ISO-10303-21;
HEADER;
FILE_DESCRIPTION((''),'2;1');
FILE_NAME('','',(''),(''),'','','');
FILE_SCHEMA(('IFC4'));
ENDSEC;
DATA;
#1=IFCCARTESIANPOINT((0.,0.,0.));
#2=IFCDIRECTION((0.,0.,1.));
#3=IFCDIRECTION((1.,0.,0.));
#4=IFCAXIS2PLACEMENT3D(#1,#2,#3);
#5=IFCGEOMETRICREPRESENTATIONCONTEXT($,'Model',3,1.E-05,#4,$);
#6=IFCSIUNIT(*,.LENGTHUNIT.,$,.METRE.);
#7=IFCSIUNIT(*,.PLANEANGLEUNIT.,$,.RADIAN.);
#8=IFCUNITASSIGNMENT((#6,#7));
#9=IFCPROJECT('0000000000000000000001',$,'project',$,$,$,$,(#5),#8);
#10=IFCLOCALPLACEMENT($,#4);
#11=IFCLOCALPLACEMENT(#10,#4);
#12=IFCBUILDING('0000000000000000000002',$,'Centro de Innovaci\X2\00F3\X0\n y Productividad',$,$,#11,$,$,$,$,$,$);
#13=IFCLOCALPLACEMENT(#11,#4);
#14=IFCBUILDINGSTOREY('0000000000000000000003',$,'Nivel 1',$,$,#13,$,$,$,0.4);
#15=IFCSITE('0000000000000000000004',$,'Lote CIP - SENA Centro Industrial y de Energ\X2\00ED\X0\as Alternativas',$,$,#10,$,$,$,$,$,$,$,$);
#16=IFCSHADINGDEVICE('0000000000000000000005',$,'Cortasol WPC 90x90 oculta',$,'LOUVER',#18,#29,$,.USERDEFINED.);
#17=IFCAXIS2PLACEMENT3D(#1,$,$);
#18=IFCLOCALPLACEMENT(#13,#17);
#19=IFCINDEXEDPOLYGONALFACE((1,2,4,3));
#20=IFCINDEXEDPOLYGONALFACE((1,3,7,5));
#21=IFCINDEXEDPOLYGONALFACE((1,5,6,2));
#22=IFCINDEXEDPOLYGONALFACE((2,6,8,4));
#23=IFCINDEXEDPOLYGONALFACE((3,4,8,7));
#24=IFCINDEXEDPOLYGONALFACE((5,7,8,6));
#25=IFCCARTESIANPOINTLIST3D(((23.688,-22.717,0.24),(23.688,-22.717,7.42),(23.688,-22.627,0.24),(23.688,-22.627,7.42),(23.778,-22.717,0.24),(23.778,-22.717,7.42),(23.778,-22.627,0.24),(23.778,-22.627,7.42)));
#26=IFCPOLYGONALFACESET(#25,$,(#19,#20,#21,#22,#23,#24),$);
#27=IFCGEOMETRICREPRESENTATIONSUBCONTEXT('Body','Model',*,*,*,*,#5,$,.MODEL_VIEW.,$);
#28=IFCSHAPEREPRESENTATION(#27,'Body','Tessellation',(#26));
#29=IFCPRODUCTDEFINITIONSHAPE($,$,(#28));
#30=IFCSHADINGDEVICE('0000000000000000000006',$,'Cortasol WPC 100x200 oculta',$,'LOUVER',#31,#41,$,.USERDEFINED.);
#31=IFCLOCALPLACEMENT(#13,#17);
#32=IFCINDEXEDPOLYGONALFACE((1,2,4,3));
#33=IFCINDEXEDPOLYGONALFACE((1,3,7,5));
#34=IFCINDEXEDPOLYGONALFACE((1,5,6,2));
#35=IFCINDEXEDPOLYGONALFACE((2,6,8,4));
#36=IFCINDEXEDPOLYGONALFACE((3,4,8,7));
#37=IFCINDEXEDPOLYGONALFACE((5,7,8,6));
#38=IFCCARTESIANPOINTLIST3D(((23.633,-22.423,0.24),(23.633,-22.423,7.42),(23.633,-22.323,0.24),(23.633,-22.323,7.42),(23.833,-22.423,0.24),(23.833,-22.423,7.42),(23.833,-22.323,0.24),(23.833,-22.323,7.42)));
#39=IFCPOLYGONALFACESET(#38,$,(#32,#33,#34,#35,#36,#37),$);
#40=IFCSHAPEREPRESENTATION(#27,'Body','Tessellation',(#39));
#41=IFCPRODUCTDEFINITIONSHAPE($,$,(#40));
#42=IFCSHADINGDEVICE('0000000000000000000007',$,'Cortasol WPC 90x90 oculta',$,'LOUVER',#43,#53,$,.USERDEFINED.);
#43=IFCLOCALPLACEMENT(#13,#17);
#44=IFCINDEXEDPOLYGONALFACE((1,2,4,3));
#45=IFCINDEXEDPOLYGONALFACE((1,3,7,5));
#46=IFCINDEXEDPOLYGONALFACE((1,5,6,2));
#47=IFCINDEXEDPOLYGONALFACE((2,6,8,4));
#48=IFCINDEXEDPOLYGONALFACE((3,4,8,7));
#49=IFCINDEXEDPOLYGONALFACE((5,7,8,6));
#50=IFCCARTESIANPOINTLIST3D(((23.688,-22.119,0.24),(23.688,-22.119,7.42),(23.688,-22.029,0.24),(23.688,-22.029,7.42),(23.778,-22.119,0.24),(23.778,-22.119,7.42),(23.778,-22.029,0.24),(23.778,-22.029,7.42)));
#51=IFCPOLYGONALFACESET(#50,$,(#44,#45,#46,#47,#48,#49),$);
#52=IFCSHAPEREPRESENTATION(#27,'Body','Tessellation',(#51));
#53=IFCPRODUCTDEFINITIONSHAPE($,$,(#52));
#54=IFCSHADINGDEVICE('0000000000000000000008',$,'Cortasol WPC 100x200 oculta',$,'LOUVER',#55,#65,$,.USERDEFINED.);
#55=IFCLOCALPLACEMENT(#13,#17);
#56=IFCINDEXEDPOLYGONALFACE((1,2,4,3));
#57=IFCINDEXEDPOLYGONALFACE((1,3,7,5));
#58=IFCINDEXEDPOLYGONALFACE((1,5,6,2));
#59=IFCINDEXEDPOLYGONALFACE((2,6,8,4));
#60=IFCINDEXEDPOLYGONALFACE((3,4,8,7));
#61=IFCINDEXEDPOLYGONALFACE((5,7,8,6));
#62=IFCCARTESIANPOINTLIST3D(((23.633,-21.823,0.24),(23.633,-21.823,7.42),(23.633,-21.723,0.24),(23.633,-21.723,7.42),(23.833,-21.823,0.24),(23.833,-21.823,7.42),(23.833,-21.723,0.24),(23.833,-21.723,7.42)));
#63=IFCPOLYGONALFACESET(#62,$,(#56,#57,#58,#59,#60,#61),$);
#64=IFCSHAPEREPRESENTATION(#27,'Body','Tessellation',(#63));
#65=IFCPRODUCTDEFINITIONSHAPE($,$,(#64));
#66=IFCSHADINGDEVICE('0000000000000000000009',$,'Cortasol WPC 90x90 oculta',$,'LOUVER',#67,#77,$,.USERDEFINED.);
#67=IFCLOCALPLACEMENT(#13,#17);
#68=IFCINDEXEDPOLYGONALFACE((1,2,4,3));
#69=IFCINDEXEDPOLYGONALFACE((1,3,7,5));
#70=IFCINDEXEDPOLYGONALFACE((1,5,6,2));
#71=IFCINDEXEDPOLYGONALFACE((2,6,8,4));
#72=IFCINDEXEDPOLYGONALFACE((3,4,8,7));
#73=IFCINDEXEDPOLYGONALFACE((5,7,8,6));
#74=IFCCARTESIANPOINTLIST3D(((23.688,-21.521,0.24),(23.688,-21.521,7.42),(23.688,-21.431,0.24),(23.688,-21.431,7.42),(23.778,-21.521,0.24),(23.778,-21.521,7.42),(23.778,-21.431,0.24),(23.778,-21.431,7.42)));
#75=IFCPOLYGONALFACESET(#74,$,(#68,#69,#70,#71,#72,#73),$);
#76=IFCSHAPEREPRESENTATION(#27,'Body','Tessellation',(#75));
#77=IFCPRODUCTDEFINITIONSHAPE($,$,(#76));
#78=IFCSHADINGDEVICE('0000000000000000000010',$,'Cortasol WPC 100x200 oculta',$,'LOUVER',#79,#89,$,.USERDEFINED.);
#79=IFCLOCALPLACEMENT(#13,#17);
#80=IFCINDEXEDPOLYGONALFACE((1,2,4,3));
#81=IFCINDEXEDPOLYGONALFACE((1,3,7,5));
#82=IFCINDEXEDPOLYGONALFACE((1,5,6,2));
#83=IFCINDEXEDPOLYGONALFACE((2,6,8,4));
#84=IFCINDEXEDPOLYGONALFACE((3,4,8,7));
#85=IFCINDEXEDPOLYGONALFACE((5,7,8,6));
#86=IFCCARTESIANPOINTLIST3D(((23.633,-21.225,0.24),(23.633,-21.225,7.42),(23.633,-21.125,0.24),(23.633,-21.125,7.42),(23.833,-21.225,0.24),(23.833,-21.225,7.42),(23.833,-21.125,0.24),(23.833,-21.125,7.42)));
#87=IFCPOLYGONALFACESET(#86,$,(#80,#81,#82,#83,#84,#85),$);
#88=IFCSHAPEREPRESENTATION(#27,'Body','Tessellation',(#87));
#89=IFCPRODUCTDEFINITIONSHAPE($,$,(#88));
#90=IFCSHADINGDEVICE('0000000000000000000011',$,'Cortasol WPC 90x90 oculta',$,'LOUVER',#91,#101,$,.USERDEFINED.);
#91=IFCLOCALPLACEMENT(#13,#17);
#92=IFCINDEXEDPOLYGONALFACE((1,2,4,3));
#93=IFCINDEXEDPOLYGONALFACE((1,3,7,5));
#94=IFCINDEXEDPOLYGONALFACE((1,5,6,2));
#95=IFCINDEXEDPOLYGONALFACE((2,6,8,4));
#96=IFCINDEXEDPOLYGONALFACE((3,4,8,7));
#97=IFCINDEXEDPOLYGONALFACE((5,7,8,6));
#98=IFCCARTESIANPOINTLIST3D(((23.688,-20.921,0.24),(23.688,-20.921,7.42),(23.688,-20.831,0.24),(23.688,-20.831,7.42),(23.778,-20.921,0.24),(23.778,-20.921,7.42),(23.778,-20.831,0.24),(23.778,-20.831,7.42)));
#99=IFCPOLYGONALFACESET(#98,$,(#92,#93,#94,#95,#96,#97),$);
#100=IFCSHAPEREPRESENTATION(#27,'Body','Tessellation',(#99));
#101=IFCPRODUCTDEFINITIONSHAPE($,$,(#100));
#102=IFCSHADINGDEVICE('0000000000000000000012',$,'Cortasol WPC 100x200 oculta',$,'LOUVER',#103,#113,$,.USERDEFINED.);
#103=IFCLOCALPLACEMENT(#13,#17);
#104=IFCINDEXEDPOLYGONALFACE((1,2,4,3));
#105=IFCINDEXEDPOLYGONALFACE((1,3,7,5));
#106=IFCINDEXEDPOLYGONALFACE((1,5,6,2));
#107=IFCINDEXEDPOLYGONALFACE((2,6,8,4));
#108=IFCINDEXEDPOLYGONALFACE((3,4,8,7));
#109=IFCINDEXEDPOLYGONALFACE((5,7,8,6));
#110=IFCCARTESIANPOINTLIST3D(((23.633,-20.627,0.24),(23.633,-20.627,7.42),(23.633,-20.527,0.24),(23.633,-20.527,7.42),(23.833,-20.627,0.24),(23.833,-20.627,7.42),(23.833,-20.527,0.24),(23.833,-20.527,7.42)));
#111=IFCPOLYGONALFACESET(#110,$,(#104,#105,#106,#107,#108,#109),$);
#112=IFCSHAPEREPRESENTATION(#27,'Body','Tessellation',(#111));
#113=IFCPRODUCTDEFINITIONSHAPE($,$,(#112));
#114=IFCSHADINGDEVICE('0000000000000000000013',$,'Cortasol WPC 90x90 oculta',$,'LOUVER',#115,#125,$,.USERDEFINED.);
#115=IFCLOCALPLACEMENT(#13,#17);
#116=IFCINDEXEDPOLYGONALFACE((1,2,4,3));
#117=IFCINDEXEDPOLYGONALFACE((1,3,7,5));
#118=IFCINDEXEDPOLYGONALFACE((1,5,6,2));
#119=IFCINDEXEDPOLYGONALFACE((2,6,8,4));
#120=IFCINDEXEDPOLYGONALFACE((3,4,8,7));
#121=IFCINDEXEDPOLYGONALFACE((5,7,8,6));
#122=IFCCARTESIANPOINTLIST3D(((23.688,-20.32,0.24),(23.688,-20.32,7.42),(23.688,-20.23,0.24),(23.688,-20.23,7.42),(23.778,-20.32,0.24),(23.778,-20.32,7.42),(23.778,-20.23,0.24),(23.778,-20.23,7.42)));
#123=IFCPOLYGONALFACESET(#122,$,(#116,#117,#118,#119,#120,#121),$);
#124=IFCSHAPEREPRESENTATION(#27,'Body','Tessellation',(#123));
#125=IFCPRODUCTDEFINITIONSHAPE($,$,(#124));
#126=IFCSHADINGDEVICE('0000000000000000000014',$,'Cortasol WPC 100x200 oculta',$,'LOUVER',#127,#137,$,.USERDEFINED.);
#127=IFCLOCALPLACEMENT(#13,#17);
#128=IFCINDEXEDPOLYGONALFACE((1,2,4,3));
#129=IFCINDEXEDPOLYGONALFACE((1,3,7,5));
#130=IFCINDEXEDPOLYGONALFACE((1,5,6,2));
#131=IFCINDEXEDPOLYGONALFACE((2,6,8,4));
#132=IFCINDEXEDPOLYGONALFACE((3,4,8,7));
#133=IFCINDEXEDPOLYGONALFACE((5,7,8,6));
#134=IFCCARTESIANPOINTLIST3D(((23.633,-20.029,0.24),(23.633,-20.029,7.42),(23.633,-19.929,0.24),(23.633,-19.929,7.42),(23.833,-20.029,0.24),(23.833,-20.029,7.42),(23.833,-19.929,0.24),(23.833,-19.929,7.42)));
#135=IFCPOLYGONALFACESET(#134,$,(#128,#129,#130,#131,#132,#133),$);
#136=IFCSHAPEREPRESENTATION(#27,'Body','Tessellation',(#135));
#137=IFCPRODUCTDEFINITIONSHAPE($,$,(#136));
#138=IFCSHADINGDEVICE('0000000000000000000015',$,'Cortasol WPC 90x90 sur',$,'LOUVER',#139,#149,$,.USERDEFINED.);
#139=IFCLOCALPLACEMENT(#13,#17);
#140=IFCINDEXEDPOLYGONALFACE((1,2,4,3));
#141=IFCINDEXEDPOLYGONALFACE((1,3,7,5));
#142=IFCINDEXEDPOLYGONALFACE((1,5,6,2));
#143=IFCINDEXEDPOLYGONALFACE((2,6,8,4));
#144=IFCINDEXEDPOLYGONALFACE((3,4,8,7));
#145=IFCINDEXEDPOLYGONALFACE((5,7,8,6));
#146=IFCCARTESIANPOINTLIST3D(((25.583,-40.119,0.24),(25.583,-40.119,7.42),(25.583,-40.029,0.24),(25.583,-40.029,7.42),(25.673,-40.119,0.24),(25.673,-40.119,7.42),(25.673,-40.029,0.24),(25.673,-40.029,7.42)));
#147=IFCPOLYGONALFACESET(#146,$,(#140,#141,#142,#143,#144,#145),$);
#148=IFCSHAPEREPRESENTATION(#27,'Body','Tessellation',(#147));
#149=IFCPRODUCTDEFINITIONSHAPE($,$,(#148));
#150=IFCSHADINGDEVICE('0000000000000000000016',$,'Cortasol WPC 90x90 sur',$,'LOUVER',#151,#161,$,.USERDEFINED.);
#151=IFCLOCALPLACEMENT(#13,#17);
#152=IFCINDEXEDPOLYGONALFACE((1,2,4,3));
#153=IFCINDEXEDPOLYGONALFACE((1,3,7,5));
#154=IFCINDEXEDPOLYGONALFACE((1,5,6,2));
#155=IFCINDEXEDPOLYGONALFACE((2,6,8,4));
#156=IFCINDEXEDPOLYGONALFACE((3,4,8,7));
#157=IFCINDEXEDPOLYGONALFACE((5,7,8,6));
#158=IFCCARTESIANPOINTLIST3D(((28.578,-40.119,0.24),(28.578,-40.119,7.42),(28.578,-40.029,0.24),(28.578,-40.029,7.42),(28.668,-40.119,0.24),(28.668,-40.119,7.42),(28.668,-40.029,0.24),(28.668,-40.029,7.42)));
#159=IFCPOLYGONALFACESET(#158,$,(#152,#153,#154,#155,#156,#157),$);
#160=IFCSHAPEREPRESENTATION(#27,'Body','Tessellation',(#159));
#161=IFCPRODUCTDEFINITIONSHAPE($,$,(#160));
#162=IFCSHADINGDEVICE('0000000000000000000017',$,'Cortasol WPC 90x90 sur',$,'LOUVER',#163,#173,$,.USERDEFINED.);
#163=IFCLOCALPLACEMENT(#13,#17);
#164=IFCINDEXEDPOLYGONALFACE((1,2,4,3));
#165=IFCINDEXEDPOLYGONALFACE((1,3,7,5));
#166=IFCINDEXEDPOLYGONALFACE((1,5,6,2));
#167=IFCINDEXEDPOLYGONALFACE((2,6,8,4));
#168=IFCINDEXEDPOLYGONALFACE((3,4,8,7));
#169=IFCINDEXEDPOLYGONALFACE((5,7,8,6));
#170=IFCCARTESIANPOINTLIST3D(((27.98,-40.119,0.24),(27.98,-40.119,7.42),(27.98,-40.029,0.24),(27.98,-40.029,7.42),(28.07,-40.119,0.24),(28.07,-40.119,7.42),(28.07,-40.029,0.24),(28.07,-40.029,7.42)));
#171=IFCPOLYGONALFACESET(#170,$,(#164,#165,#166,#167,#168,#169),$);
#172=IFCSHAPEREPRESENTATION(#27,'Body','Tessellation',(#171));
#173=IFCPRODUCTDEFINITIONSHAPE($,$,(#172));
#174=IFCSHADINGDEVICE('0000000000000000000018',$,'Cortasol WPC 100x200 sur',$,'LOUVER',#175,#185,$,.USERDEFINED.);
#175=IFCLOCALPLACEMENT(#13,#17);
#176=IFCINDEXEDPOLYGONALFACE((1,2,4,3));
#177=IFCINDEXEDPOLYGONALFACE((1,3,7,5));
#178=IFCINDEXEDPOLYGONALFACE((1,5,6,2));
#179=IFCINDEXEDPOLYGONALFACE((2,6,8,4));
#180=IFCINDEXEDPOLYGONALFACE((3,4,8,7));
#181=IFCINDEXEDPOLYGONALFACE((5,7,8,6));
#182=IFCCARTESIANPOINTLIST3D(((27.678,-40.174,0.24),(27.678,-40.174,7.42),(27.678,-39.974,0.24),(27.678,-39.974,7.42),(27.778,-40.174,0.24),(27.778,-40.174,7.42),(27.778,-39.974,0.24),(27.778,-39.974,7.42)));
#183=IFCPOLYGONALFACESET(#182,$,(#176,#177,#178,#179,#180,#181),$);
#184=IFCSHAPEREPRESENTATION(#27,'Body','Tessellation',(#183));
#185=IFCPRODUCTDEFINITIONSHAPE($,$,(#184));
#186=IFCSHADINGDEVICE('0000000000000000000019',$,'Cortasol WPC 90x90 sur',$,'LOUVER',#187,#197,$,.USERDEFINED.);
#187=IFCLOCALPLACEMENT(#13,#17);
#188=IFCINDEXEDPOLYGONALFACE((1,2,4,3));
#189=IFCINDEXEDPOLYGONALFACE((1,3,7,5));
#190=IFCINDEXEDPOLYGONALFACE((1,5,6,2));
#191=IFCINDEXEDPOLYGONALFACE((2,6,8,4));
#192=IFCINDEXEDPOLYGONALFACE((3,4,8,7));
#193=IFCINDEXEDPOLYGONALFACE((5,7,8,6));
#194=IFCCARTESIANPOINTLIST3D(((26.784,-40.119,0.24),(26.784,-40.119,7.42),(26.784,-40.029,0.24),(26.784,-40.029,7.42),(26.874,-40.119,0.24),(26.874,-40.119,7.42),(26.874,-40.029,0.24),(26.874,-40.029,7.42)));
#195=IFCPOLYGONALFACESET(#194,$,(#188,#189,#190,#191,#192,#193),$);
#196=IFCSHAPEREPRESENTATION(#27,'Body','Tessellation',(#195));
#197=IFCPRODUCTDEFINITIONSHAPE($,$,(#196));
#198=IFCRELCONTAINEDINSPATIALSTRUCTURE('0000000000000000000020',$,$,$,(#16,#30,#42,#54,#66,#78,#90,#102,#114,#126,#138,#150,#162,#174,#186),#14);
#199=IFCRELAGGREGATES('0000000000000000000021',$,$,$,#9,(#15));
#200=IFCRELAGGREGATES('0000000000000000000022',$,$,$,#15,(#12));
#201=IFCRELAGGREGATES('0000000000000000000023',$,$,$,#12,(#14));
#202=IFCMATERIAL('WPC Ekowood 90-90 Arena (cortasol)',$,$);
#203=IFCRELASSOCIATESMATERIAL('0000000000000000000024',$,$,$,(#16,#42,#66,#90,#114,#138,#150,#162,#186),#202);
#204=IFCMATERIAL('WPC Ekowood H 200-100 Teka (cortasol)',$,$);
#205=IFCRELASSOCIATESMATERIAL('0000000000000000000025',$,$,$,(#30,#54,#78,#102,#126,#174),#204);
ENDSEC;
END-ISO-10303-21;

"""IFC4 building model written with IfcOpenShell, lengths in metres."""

from ifc_helpers import new_model, si_unit, frame, origin_with_axes, place, context, subcontext, project, spatial, polyline, outline, extrude, material, element, save


model = new_model("IFC4")

# Units and contexts
model_context = context("Model", 3, precision=1e-05, world=origin_with_axes())
body_context = subcontext(model_context, "Body", "Model", "MODEL_VIEW")
ifc_project = project(units=[si_unit("LENGTHUNIT", "METRE"), si_unit("PLANEANGLEUNIT", "RADIAN")], contexts=[model_context])

# Site, building, storey
site_placement = place(None, origin_with_axes())
site = spatial("IfcSite", under=ifc_project, at=site_placement, Name="Lote CIP - SENA Centro Industrial y de Energías Alternativas")
building_placement = place(site_placement, origin_with_axes())
building = spatial("IfcBuilding", under=site, at=building_placement, Name="Centro de Innovación y Productividad")
storey_placement = place(building_placement, origin_with_axes())
storey = spatial("IfcBuildingStorey", under=building, at=storey_placement, Name="Nivel 1", Elevation=0.4)

# Shading devices
ifc_material_1 = material(Name="WPC Ekowood 90-90 Arena (cortasol)")
shading_device_1_placement = place(storey_placement, origin_with_axes())
element("IfcShadingDevice", 1, at=shading_device_1_placement, inside=storey, material=ifc_material_1, Name="Cortasol WPC 90x90 oculta", ObjectType="LOUVER", PredefinedType="USERDEFINED", context=body_context, shape_type="SweptSolid", body=[
    extrude(outline(polyline([(23.778, -22.717), (23.688, -22.717), (23.688, -22.627), (23.778, -22.627), (23.778, -22.717)])), frame((0.0, 0.0, 0.24)), (0.0, 0.0, 1.0), 7.18),
])
ifc_material_2 = material(Name="WPC Ekowood H 200-100 Teka (cortasol)")
shading_device_2_placement = place(storey_placement, origin_with_axes())
element("IfcShadingDevice", 2, at=shading_device_2_placement, inside=storey, material=ifc_material_2, Name="Cortasol WPC 100x200 oculta", ObjectType="LOUVER", PredefinedType="USERDEFINED", context=body_context, shape_type="SweptSolid", body=[
    extrude(outline(polyline([(23.833, -22.423), (23.633, -22.423), (23.633, -22.323), (23.833, -22.323), (23.833, -22.423)])), frame((0.0, 0.0, 0.24)), (0.0, 0.0, 1.0), 7.18),
])
shading_device_3_placement = place(storey_placement, origin_with_axes())
element("IfcShadingDevice", 3, at=shading_device_3_placement, inside=storey, material=ifc_material_1, Name="Cortasol WPC 90x90 oculta", ObjectType="LOUVER", PredefinedType="USERDEFINED", context=body_context, shape_type="SweptSolid", body=[
    extrude(outline(polyline([(23.778, -22.119), (23.688, -22.119), (23.688, -22.029), (23.778, -22.029), (23.778, -22.119)])), frame((0.0, 0.0, 0.24)), (0.0, 0.0, 1.0), 7.18),
])
shading_device_4_placement = place(storey_placement, origin_with_axes())
element("IfcShadingDevice", 4, at=shading_device_4_placement, inside=storey, material=ifc_material_2, Name="Cortasol WPC 100x200 oculta", ObjectType="LOUVER", PredefinedType="USERDEFINED", context=body_context, shape_type="SweptSolid", body=[
    extrude(outline(polyline([(23.833, -21.823), (23.633, -21.823), (23.633, -21.723), (23.833, -21.723), (23.833, -21.823)])), frame((0.0, 0.0, 0.24)), (0.0, 0.0, 1.0), 7.18),
])
shading_device_5_placement = place(storey_placement, origin_with_axes())
element("IfcShadingDevice", 5, at=shading_device_5_placement, inside=storey, material=ifc_material_1, Name="Cortasol WPC 90x90 oculta", ObjectType="LOUVER", PredefinedType="USERDEFINED", context=body_context, shape_type="SweptSolid", body=[
    extrude(outline(polyline([(23.778, -21.521), (23.688, -21.521), (23.688, -21.431), (23.778, -21.431), (23.778, -21.521)])), frame((0.0, 0.0, 0.24)), (0.0, 0.0, 1.0), 7.18),
])
shading_device_6_placement = place(storey_placement, origin_with_axes())
element("IfcShadingDevice", 6, at=shading_device_6_placement, inside=storey, material=ifc_material_2, Name="Cortasol WPC 100x200 oculta", ObjectType="LOUVER", PredefinedType="USERDEFINED", context=body_context, shape_type="SweptSolid", body=[
    extrude(outline(polyline([(23.833, -21.225), (23.633, -21.225), (23.633, -21.125), (23.833, -21.125), (23.833, -21.225)])), frame((0.0, 0.0, 0.24)), (0.0, 0.0, 1.0), 7.18),
])
shading_device_7_placement = place(storey_placement, origin_with_axes())
element("IfcShadingDevice", 7, at=shading_device_7_placement, inside=storey, material=ifc_material_1, Name="Cortasol WPC 90x90 oculta", ObjectType="LOUVER", PredefinedType="USERDEFINED", context=body_context, shape_type="SweptSolid", body=[
    extrude(outline(polyline([(23.778, -20.921), (23.688, -20.921), (23.688, -20.831), (23.778, -20.831), (23.778, -20.921)])), frame((0.0, 0.0, 0.24)), (0.0, 0.0, 1.0), 7.18),
])
shading_device_8_placement = place(storey_placement, origin_with_axes())
element("IfcShadingDevice", 8, at=shading_device_8_placement, inside=storey, material=ifc_material_2, Name="Cortasol WPC 100x200 oculta", ObjectType="LOUVER", PredefinedType="USERDEFINED", context=body_context, shape_type="SweptSolid", body=[
    extrude(outline(polyline([(23.833, -20.627), (23.633, -20.627), (23.633, -20.527), (23.833, -20.527), (23.833, -20.627)])), frame((0.0, 0.0, 0.24)), (0.0, 0.0, 1.0), 7.18),
])
shading_device_9_placement = place(storey_placement, origin_with_axes())
element("IfcShadingDevice", 9, at=shading_device_9_placement, inside=storey, material=ifc_material_1, Name="Cortasol WPC 90x90 oculta", ObjectType="LOUVER", PredefinedType="USERDEFINED", context=body_context, shape_type="SweptSolid", body=[
    extrude(outline(polyline([(23.778, -20.32), (23.688, -20.32), (23.688, -20.23), (23.778, -20.23), (23.778, -20.32)])), frame((0.0, 0.0, 0.24)), (0.0, 0.0, 1.0), 7.18),
])
shading_device_10_placement = place(storey_placement, origin_with_axes())
element("IfcShadingDevice", 10, at=shading_device_10_placement, inside=storey, material=ifc_material_2, Name="Cortasol WPC 100x200 oculta", ObjectType="LOUVER", PredefinedType="USERDEFINED", context=body_context, shape_type="SweptSolid", body=[
    extrude(outline(polyline([(23.833, -20.029), (23.633, -20.029), (23.633, -19.929), (23.833, -19.929), (23.833, -20.029)])), frame((0.0, 0.0, 0.24)), (0.0, 0.0, 1.0), 7.18),
])
shading_device_11_placement = place(storey_placement, origin_with_axes())
element("IfcShadingDevice", 11, at=shading_device_11_placement, inside=storey, material=ifc_material_1, Name="Cortasol WPC 90x90 sur", ObjectType="LOUVER", PredefinedType="USERDEFINED", context=body_context, shape_type="SweptSolid", body=[
    extrude(outline(polyline([(25.583, -40.119), (25.583, -40.029), (25.673, -40.029), (25.673, -40.119), (25.583, -40.119)])), frame((0.0, 0.0, 0.24)), (0.0, 0.0, 1.0), 7.18),
])
shading_device_12_placement = place(storey_placement, origin_with_axes())
element("IfcShadingDevice", 12, at=shading_device_12_placement, inside=storey, material=ifc_material_1, Name="Cortasol WPC 90x90 sur", ObjectType="LOUVER", PredefinedType="USERDEFINED", context=body_context, shape_type="SweptSolid", body=[
    extrude(outline(polyline([(28.578, -40.119), (28.578, -40.029), (28.668, -40.029), (28.668, -40.119), (28.578, -40.119)])), frame((0.0, 0.0, 0.24)), (0.0, 0.0, 1.0), 7.18),
])
shading_device_13_placement = place(storey_placement, origin_with_axes())
element("IfcShadingDevice", 13, at=shading_device_13_placement, inside=storey, material=ifc_material_1, Name="Cortasol WPC 90x90 sur", ObjectType="LOUVER", PredefinedType="USERDEFINED", context=body_context, shape_type="SweptSolid", body=[
    extrude(outline(polyline([(27.98, -40.119), (27.98, -40.029), (28.07, -40.029), (28.07, -40.119), (27.98, -40.119)])), frame((0.0, 0.0, 0.24)), (0.0, 0.0, 1.0), 7.18),
])
shading_device_14_placement = place(storey_placement, origin_with_axes())
element("IfcShadingDevice", 14, at=shading_device_14_placement, inside=storey, material=ifc_material_2, Name="Cortasol WPC 100x200 sur", ObjectType="LOUVER", PredefinedType="USERDEFINED", context=body_context, shape_type="SweptSolid", body=[
    extrude(outline(polyline([(27.678, -40.174), (27.678, -39.974), (27.778, -39.974), (27.778, -40.174), (27.678, -40.174)])), frame((0.0, 0.0, 0.24)), (0.0, 0.0, 1.0), 7.18),
])
shading_device_15_placement = place(storey_placement, origin_with_axes())
element("IfcShadingDevice", 15, at=shading_device_15_placement, inside=storey, material=ifc_material_1, Name="Cortasol WPC 90x90 sur", ObjectType="LOUVER", PredefinedType="USERDEFINED", context=body_context, shape_type="SweptSolid", body=[
    extrude(outline(polyline([(26.784, -40.119), (26.784, -40.029), (26.874, -40.029), (26.874, -40.119), (26.784, -40.119)])), frame((0.0, 0.0, 0.24)), (0.0, 0.0, 1.0), 7.18),
])

save(model, "model.ifc")
